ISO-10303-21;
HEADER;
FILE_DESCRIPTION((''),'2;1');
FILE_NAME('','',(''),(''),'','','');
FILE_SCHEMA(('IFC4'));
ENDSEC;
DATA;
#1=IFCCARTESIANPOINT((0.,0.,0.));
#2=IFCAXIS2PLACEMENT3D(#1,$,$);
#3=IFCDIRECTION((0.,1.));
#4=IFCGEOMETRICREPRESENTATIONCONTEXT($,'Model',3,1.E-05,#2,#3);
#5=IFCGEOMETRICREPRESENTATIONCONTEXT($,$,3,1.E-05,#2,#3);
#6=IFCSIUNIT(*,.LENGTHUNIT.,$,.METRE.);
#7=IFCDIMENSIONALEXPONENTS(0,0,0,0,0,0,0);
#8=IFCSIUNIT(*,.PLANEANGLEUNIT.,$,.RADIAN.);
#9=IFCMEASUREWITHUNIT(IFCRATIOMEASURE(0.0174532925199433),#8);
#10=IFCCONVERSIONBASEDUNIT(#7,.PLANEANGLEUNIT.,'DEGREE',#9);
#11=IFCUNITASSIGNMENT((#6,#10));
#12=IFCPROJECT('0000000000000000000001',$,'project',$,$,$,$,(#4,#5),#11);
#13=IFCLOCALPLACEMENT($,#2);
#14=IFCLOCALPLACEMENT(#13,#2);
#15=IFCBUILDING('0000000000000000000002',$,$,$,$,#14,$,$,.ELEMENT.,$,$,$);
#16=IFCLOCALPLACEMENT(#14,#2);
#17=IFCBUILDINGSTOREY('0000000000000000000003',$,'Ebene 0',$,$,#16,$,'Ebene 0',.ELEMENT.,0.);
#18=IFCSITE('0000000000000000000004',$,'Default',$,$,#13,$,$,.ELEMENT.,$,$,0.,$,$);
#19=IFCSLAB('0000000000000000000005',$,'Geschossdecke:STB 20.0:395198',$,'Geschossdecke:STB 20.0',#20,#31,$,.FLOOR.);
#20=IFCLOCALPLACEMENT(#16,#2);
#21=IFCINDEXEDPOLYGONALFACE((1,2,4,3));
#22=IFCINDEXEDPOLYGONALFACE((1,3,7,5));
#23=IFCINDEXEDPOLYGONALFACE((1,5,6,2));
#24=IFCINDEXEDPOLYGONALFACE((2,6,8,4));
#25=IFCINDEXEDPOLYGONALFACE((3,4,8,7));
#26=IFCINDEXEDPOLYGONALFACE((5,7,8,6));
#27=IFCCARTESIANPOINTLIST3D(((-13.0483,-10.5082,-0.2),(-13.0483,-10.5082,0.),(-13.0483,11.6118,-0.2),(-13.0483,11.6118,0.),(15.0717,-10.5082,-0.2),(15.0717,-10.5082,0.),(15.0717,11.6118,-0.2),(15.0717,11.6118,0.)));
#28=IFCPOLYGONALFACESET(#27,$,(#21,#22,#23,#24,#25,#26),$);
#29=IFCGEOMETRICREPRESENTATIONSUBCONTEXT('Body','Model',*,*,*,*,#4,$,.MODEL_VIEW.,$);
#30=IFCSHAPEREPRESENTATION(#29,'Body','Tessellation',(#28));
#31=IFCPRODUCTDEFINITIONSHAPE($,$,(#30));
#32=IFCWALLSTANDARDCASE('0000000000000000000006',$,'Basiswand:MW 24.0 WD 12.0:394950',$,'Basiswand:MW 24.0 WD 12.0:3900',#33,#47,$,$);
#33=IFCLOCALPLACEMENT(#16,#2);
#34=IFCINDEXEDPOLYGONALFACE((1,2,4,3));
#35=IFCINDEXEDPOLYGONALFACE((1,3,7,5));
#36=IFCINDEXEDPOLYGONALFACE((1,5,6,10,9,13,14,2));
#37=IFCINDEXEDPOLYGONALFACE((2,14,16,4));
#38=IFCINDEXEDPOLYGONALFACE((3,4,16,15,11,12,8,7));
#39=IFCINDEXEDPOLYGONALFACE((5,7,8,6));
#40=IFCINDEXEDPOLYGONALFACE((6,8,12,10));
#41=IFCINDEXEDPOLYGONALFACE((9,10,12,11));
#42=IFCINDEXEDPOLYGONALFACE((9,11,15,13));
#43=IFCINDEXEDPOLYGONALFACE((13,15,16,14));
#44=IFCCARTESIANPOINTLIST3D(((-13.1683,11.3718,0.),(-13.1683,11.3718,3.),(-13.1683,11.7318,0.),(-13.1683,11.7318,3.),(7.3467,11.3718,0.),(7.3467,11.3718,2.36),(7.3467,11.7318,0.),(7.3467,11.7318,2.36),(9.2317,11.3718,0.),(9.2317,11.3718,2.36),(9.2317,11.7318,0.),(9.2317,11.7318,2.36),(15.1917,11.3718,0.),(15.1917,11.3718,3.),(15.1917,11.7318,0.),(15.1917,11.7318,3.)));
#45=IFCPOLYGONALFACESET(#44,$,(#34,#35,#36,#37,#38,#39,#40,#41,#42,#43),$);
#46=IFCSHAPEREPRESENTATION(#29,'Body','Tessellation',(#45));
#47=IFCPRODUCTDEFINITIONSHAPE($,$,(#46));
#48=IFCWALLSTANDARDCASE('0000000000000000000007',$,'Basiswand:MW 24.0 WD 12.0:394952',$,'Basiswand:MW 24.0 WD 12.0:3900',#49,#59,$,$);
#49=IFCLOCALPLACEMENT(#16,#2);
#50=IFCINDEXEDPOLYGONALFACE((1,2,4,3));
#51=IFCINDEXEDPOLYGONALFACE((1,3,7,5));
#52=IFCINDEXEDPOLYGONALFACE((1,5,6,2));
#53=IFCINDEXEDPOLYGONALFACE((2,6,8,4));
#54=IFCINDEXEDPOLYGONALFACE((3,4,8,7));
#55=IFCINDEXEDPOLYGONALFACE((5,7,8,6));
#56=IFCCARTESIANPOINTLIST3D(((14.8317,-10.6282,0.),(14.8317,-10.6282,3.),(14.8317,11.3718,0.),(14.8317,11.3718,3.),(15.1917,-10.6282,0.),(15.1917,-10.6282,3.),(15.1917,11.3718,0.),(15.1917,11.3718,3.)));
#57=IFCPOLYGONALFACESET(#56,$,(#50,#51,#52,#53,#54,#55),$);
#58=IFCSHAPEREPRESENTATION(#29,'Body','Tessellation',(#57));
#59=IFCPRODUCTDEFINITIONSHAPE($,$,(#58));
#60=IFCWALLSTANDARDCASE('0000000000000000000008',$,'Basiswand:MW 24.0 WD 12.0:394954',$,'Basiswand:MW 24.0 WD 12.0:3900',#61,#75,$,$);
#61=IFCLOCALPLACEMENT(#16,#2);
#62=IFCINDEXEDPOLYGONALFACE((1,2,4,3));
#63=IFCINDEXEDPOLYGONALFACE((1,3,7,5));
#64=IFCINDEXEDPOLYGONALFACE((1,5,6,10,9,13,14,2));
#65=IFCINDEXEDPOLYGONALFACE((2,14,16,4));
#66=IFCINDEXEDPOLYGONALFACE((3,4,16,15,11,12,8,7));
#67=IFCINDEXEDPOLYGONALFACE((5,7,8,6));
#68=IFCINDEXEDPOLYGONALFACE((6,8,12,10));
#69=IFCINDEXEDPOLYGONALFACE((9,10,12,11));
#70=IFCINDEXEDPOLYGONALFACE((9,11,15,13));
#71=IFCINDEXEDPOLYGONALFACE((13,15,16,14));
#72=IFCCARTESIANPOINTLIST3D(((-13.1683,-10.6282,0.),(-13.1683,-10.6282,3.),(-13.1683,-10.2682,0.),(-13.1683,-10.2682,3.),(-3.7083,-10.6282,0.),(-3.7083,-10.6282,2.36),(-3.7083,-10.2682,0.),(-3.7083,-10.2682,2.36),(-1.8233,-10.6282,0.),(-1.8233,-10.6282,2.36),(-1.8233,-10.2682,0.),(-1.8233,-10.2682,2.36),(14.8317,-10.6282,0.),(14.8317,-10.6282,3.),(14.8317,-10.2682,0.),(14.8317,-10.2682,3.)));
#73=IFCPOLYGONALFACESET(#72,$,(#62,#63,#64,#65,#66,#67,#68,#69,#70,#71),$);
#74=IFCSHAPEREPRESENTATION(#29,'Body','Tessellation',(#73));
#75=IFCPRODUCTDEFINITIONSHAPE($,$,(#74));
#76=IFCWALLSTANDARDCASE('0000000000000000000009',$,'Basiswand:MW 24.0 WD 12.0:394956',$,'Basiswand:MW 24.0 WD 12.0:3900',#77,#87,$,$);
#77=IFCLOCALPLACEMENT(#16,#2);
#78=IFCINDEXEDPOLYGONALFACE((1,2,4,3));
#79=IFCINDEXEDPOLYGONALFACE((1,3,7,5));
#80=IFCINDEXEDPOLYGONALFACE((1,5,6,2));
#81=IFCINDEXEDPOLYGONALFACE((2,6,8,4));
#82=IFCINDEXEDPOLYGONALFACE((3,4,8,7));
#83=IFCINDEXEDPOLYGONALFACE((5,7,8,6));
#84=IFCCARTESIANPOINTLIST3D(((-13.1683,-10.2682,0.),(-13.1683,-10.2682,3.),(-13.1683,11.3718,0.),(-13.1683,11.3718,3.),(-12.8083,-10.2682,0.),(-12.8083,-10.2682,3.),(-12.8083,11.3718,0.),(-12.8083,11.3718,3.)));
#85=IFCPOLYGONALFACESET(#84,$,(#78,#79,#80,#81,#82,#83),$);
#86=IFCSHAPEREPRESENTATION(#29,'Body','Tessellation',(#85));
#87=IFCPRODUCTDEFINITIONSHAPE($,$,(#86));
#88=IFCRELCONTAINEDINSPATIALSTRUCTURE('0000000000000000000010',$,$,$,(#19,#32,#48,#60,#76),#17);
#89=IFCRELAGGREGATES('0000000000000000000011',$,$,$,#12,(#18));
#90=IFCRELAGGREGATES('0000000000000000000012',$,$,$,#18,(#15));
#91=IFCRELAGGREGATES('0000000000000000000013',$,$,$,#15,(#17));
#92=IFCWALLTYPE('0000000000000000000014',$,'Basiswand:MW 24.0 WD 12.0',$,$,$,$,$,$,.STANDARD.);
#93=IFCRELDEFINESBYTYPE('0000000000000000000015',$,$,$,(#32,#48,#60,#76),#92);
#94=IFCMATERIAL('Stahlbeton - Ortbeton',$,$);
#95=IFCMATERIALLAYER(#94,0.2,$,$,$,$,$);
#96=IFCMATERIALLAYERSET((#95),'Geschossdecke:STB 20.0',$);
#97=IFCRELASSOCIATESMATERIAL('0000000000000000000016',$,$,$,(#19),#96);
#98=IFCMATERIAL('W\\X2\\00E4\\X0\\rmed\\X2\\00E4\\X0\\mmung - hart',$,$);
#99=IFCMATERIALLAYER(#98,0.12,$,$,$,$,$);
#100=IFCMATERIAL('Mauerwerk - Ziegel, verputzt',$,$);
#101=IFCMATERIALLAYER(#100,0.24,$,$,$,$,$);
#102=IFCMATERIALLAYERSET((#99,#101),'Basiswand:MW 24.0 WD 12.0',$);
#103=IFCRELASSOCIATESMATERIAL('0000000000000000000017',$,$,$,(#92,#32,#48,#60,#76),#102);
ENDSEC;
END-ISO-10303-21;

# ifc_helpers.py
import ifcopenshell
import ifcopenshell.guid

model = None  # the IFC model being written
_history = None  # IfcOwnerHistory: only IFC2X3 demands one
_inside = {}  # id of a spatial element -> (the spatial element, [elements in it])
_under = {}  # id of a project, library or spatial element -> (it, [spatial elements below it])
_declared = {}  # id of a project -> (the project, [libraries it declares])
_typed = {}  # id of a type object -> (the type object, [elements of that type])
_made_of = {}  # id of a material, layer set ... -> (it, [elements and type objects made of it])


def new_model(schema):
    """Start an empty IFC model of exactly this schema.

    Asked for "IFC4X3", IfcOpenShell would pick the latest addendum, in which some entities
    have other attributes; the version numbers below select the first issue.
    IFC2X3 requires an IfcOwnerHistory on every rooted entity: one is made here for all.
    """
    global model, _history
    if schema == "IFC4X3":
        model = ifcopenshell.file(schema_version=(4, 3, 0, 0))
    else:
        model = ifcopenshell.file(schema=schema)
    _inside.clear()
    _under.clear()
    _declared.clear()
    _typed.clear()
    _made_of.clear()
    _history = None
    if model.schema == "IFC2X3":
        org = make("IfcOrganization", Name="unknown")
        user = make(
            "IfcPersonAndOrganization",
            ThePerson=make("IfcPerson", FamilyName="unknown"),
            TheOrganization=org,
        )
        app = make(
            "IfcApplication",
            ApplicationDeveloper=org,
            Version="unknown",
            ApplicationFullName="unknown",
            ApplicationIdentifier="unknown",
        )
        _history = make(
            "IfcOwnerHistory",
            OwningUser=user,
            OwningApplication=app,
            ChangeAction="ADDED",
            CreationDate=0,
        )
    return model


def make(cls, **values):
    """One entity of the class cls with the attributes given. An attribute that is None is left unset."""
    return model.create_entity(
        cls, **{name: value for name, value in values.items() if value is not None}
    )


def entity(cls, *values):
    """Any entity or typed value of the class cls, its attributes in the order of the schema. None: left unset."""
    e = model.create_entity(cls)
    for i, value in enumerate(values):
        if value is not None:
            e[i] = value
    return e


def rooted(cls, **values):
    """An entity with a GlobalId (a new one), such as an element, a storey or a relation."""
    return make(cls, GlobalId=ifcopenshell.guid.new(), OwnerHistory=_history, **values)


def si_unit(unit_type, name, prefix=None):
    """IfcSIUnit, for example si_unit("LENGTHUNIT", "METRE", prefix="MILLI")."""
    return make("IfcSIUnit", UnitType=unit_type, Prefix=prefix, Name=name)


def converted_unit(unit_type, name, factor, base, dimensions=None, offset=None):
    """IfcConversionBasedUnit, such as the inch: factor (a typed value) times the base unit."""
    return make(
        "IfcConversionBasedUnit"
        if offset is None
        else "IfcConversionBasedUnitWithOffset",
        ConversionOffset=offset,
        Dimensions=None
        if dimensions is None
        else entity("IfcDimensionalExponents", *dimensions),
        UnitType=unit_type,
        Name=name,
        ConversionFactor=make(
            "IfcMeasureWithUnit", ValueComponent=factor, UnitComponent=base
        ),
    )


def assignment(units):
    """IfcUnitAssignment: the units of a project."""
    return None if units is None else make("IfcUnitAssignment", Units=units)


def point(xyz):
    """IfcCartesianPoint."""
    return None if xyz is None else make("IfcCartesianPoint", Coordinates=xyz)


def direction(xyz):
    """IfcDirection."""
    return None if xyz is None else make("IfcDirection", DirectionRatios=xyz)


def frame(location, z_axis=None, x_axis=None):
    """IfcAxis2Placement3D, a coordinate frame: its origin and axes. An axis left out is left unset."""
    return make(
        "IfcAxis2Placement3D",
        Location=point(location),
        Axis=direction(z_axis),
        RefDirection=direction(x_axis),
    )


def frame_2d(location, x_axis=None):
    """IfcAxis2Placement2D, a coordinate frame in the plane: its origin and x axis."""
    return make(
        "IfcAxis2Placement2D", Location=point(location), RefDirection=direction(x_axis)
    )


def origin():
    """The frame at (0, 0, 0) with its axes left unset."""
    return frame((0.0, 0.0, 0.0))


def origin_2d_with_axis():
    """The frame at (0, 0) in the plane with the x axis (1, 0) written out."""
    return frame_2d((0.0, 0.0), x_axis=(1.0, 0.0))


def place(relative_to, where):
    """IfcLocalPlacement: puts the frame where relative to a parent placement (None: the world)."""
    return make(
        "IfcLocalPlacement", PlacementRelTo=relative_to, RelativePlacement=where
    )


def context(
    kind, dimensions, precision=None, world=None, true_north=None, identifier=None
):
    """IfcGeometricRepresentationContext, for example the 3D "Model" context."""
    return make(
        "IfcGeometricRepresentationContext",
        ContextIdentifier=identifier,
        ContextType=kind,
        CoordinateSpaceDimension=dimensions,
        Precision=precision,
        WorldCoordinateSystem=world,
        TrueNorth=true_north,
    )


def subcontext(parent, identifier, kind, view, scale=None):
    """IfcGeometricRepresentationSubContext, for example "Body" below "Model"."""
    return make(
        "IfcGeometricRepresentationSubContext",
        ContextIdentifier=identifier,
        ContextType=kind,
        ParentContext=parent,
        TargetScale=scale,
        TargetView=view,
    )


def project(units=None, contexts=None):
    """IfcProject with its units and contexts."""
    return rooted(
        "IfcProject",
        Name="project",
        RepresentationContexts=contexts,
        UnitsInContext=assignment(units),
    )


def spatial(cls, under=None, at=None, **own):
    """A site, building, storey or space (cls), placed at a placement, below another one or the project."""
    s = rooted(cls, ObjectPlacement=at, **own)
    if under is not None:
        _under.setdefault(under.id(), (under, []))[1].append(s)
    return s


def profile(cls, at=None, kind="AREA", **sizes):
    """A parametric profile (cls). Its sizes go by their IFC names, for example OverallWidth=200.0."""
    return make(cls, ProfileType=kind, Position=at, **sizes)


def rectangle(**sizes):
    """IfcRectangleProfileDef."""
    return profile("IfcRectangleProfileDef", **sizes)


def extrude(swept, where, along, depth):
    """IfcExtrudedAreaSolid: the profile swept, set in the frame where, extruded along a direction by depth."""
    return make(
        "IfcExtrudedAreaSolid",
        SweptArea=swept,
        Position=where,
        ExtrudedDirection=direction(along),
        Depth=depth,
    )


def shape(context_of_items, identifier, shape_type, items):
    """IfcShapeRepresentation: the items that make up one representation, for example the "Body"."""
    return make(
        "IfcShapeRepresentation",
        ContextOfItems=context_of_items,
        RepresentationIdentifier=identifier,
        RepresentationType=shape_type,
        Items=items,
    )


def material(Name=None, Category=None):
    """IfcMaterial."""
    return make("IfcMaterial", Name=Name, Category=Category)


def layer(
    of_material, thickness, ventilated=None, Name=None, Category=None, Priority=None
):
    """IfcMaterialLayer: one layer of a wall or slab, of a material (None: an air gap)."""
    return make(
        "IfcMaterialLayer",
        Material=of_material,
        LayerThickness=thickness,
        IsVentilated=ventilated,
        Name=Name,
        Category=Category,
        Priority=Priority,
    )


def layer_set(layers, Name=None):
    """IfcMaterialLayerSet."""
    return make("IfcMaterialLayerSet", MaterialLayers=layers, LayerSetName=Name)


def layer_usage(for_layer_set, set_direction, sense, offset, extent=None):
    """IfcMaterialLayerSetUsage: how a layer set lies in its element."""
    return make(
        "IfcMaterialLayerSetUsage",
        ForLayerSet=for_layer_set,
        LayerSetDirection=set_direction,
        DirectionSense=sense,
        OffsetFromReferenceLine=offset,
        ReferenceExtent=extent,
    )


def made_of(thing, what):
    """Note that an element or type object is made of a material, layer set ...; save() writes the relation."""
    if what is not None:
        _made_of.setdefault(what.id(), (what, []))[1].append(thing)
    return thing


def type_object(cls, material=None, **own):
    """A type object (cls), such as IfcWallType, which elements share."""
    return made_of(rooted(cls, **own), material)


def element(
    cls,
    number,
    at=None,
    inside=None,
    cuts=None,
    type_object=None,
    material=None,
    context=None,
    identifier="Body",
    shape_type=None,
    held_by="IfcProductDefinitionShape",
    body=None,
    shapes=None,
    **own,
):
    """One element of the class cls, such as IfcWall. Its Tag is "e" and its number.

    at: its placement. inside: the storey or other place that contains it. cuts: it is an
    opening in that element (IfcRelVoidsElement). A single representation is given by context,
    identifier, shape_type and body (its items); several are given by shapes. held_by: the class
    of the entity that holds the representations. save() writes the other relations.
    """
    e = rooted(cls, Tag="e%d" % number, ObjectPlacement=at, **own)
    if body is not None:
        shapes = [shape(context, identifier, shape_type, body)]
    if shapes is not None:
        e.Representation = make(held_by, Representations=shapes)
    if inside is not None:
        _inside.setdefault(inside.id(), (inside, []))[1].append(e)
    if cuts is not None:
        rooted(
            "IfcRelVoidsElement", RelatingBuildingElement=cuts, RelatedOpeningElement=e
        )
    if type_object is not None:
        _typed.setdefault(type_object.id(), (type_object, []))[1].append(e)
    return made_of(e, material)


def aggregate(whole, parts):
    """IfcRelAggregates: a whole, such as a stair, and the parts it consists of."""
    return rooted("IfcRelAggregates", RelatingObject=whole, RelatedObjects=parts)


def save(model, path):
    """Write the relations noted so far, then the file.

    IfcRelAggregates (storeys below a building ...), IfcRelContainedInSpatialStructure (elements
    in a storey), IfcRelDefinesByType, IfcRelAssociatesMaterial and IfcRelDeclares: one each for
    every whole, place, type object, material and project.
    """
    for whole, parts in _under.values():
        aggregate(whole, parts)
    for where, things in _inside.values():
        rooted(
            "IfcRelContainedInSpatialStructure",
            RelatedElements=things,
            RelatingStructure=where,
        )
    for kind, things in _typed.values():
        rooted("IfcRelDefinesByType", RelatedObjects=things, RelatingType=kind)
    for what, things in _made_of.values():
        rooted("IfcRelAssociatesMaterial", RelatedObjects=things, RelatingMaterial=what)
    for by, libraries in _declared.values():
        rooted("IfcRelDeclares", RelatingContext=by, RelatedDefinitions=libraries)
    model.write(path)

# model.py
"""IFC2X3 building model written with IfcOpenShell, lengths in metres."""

from ifc_helpers import new_model, entity, si_unit, converted_unit, direction, frame, frame_2d, origin, origin_2d_with_axis, place, context, subcontext, project, spatial, rectangle, extrude, material, layer, layer_set, layer_usage, type_object, element, save


model = new_model("IFC2X3")

# Units and contexts
model_context = context("Model", 3, precision=1e-05, world=origin(), true_north=direction((0.0, 1.0)))
context_of_model = context(None, 3, precision=1e-05, world=origin(), true_north=direction((0.0, 1.0)))
body_context = subcontext(model_context, "Body", "Model", "MODEL_VIEW")
ifc_project = project(units=[si_unit("LENGTHUNIT", "METRE"), converted_unit("PLANEANGLEUNIT", "DEGREE", entity("IfcRatioMeasure", 0.0174532925199433), si_unit("PLANEANGLEUNIT", "RADIAN"), dimensions=[0, 0, 0, 0, 0, 0, 0])], contexts=[model_context, context_of_model])

# Site, building, storey
site_placement = place(None, origin())
site = spatial("IfcSite", under=ifc_project, at=site_placement, Name="Default", CompositionType="ELEMENT", RefElevation=0.0)
building_placement = place(site_placement, origin())
building = spatial("IfcBuilding", under=site, at=building_placement, CompositionType="ELEMENT")
storey_placement = place(building_placement, origin())
storey = spatial("IfcBuildingStorey", under=building, at=storey_placement, Name="Ebene 0", LongName="Ebene 0", CompositionType="ELEMENT", Elevation=0.0)

# Slab
ifc_material_1 = material(Name="Stahlbeton - Ortbeton")
ifc_layer_1 = layer(ifc_material_1, 0.2)
ifc_layer_set_1 = layer_set([ifc_layer_1], Name="Geschossdecke:STB 20.0")
ifc_layer_usage_1 = layer_usage(ifc_layer_set_1, "AXIS3", "POSITIVE", 0.0)
slab_placement = place(storey_placement, origin())
element("IfcSlab", 1, at=slab_placement, inside=storey, material=ifc_layer_usage_1, Name="Geschossdecke:STB 20.0:395198", ObjectType="Geschossdecke:STB 20.0", PredefinedType="FLOOR", context=body_context, shape_type="SweptSolid", body=[
    extrude(rectangle(XDim=22.12, YDim=28.12, at=origin_2d_with_axis()), frame((1.0117, 0.5518, 0.0), z_axis=(0.0, 0.0, -1.0), x_axis=(0.0, 1.0, 0.0)), (0.0, 0.0, 1.0), 0.2),
])

# Wall, opening
ifc_material_2 = material(Name="W\\X2\\00E4\\X0\\rmed\\X2\\00E4\\X0\\mmung - hart")
ifc_layer_2 = layer(ifc_material_2, 0.12)
ifc_material_3 = material(Name="Mauerwerk - Ziegel, verputzt")
ifc_layer_3 = layer(ifc_material_3, 0.24)
ifc_layer_set_2 = layer_set([ifc_layer_2, ifc_layer_3], Name="Basiswand:MW 24.0 WD 12.0")
ifc_layer_usage_2 = layer_usage(ifc_layer_set_2, "AXIS2", "NEGATIVE", 0.18)
wall_type = type_object("IfcWallType", Name="Basiswand:MW 24.0 WD 12.0", PredefinedType="STANDARD", material=ifc_layer_set_2)
wall_1_placement = place(storey_placement, frame((-13.1683, 11.5518, 0.0)))
wall_1 = element("IfcWallStandardCase", 2, at=wall_1_placement, inside=storey, type_object=wall_type, material=ifc_layer_usage_2, Name="Basiswand:MW 24.0 WD 12.0:394950", ObjectType="Basiswand:MW 24.0 WD 12.0:3900", context=body_context, shape_type="SweptSolid", body=[
    extrude(rectangle(XDim=28.36, YDim=0.36, at=frame_2d((14.18, 0.0), x_axis=(-1.0, 0.0))), origin(), (0.0, 0.0, 1.0), 3.0),
])
opening_1_placement = place(wall_1_placement, frame((20.515, -0.18, 0.0)))
element("IfcOpeningElement", 3, at=opening_1_placement, cuts=wall_1, ObjectType="Opening", context=body_context, shape_type="SweptSolid", body=[
    extrude(rectangle(XDim=2.36, YDim=1.885, at=frame_2d((1.18, 0.9425), x_axis=(1.0, 0.0))), frame((0.0, 0.0, 0.0), z_axis=(0.0, 1.0, 0.0), x_axis=(0.0, 0.0, 1.0)), (0.0, 0.0, 1.0), 0.36),
])

# Wall
wall_2_placement = place(storey_placement, frame((15.0117, 11.3718, 0.0), z_axis=(0.0, 0.0, 1.0), x_axis=(0.0, -1.0, 0.0)))
element("IfcWallStandardCase", 4, at=wall_2_placement, inside=storey, type_object=wall_type, material=ifc_layer_usage_2, Name="Basiswand:MW 24.0 WD 12.0:394952", ObjectType="Basiswand:MW 24.0 WD 12.0:3900", context=body_context, shape_type="SweptSolid", body=[
    extrude(rectangle(XDim=22.0, YDim=0.36, at=frame_2d((11.0, 0.0), x_axis=(-1.0, 0.0))), origin(), (0.0, 0.0, 1.0), 3.0),
])

# Wall, opening
wall_3_placement = place(storey_placement, frame((14.8317, -10.4482, 0.0), z_axis=(0.0, 0.0, 1.0), x_axis=(-1.0, 0.0, 0.0)))
wall_3 = element("IfcWallStandardCase", 5, at=wall_3_placement, inside=storey, type_object=wall_type, material=ifc_layer_usage_2, Name="Basiswand:MW 24.0 WD 12.0:394954", ObjectType="Basiswand:MW 24.0 WD 12.0:3900", context=body_context, shape_type="SweptSolid", body=[
    extrude(rectangle(XDim=28.0, YDim=0.36, at=frame_2d((14.0, 0.0), x_axis=(-1.0, 0.0))), origin(), (0.0, 0.0, 1.0), 3.0),
])
opening_2_placement = place(wall_3_placement, frame((16.655, -0.18, 0.0)))
element("IfcOpeningElement", 6, at=opening_2_placement, cuts=wall_3, ObjectType="Opening", context=body_context, shape_type="SweptSolid", body=[
    extrude(rectangle(XDim=2.36, YDim=1.885, at=frame_2d((1.18, 0.9425), x_axis=(1.0, 0.0))), frame((0.0, 0.0, 0.0), z_axis=(0.0, 1.0, 0.0), x_axis=(0.0, 0.0, 1.0)), (0.0, 0.0, 1.0), 0.36),
])

# Wall
wall_4_placement = place(storey_placement, frame((-12.9883, -10.2682, 0.0), z_axis=(0.0, 0.0, 1.0), x_axis=(0.0, 1.0, 0.0)))
element("IfcWallStandardCase", 7, at=wall_4_placement, inside=storey, type_object=wall_type, material=ifc_layer_usage_2, Name="Basiswand:MW 24.0 WD 12.0:394956", ObjectType="Basiswand:MW 24.0 WD 12.0:3900", context=body_context, shape_type="SweptSolid", body=[
    extrude(rectangle(XDim=21.64, YDim=0.36, at=frame_2d((10.82, 0.0), x_axis=(-1.0, 0.0))), origin(), (0.0, 0.0, 1.0), 3.0),
])

save(model, "model.ifc")
